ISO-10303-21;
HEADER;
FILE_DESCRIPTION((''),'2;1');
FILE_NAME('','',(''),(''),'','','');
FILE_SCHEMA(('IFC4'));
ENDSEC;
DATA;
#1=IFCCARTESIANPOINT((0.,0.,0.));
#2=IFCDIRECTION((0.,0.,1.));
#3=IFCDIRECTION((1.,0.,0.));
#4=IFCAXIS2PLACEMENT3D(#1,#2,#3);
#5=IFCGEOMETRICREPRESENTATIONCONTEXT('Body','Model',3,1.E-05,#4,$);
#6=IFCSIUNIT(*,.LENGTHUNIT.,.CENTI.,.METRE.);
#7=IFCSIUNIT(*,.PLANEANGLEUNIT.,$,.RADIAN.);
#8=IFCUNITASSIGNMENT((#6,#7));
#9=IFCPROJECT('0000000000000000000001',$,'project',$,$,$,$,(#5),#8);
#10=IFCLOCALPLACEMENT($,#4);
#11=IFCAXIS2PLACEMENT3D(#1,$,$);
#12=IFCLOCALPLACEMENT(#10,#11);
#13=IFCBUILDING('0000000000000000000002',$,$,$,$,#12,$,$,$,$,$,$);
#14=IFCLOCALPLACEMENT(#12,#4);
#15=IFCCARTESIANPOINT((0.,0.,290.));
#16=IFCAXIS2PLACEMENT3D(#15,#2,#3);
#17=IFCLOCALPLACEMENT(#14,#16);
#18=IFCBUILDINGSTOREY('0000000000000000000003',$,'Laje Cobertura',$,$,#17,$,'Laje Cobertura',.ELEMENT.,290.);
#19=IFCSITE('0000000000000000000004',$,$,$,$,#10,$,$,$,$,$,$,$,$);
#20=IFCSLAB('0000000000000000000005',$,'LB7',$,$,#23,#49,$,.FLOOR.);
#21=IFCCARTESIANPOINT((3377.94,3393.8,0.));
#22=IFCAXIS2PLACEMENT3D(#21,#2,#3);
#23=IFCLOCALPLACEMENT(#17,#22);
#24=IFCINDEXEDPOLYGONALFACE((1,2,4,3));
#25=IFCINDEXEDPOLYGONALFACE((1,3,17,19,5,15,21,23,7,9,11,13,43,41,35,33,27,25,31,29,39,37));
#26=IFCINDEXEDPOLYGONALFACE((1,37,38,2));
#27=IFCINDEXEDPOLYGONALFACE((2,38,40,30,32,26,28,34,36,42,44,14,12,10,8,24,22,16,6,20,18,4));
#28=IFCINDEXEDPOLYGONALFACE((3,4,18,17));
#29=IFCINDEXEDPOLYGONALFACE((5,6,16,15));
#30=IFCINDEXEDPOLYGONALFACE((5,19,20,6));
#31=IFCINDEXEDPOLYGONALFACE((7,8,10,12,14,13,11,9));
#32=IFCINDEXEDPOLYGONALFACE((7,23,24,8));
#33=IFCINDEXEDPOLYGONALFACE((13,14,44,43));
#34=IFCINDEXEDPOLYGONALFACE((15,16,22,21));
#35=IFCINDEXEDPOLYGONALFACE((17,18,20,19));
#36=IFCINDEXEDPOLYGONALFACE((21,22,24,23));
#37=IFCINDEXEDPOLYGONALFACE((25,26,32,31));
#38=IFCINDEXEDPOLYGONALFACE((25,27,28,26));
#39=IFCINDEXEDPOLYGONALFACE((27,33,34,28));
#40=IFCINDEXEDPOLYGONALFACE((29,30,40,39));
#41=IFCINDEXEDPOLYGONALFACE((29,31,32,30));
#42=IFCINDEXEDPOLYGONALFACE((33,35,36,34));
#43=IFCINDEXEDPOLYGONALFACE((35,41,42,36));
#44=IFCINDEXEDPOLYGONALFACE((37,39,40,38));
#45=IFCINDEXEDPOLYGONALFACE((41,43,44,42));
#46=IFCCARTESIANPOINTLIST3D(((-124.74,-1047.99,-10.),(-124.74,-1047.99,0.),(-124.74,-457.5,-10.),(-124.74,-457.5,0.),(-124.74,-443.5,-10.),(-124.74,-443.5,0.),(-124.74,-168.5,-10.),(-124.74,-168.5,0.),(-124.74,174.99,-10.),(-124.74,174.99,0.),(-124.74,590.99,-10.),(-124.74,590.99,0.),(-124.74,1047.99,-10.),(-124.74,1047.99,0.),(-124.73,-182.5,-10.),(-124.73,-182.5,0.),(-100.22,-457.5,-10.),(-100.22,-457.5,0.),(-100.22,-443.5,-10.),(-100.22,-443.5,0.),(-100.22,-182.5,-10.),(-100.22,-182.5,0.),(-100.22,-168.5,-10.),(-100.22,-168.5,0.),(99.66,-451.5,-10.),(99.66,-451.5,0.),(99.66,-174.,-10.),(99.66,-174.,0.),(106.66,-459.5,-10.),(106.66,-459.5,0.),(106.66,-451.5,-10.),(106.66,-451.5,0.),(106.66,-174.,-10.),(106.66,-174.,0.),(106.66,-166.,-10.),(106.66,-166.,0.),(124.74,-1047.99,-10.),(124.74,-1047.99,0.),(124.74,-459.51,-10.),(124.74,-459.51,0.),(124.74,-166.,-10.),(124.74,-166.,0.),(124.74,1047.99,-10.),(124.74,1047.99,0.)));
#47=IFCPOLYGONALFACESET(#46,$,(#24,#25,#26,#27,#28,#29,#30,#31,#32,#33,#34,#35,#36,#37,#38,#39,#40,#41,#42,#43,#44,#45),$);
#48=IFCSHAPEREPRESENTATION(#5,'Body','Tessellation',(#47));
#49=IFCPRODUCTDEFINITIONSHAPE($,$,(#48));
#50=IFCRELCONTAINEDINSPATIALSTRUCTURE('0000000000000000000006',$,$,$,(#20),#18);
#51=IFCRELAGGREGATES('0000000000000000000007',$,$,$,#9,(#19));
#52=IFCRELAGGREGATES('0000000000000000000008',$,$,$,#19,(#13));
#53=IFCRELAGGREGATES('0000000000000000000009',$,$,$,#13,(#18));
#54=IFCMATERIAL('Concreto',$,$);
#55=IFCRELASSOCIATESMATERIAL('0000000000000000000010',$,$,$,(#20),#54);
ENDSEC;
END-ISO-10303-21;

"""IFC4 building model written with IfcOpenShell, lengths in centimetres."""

from ifc_helpers import new_model, si_unit, frame, origin, origin_with_axes, place, context, project, spatial, polyline, outline, extrude, material, element, save


model = new_model("IFC4")

# Units and contexts
model_context = context("Model", 3, precision=1e-05, world=origin_with_axes(), identifier="Body")
ifc_project = project(units=[si_unit("LENGTHUNIT", "METRE", prefix="CENTI"), si_unit("PLANEANGLEUNIT", "RADIAN")], contexts=[model_context])

# Site, building, storey
site_placement = place(None, origin_with_axes())
site = spatial("IfcSite", under=ifc_project, at=site_placement)
building_placement = place(site_placement, origin())
building = spatial("IfcBuilding", under=site, at=building_placement)
placement = place(building_placement, origin_with_axes())
storey_placement = place(placement, frame((0.0, 0.0, 290.0), z_axis=(0.0, 0.0, 1.0), x_axis=(1.0, 0.0, 0.0)))
storey = spatial("IfcBuildingStorey", under=building, at=storey_placement, Name="Laje Cobertura", LongName="Laje Cobertura", CompositionType="ELEMENT", Elevation=290.0)

# Shared definitions
ifc_material = material(Name="Concreto")

# Slab
slab_1_placement = place(storey_placement, frame((3377.94, 3393.8, 0.0), z_axis=(0.0, 0.0, 1.0), x_axis=(1.0, 0.0, 0.0)))
element("IfcSlab", 1, at=slab_1_placement, inside=storey, material=ifc_material, Name="LB7", PredefinedType="FLOOR", context=model_context, shape_type="SolidModel", body=[
    extrude(outline(polyline([(124.74, -459.5), (106.66, -459.5), (106.66, -451.5), (99.66, -451.5), (99.66, -174.0), (106.66, -174.0), (106.66, -166.0), (124.75, -166.0), (124.74, 1047.99), (-124.73, 1047.99), (-124.73, 591.0), (-124.74, 175.0), (-124.73, -168.5), (-100.22, -168.5), (-100.22, -182.5), (-124.73, -182.5), (-124.73, -443.5), (-100.22, -443.5), (-100.22, -457.5), (-124.73, -457.5), (-124.73, -1047.99), (124.74, -1047.99), (124.74, -459.5), (124.74, -459.5)])), frame((0.0, 0.0, -10.0), z_axis=(0.0, 0.0, 1.0), x_axis=(1.0, 0.0, 0.0)), (0.0, 0.0, 1.0), 10.0),
])

save(model, "model.ifc")
